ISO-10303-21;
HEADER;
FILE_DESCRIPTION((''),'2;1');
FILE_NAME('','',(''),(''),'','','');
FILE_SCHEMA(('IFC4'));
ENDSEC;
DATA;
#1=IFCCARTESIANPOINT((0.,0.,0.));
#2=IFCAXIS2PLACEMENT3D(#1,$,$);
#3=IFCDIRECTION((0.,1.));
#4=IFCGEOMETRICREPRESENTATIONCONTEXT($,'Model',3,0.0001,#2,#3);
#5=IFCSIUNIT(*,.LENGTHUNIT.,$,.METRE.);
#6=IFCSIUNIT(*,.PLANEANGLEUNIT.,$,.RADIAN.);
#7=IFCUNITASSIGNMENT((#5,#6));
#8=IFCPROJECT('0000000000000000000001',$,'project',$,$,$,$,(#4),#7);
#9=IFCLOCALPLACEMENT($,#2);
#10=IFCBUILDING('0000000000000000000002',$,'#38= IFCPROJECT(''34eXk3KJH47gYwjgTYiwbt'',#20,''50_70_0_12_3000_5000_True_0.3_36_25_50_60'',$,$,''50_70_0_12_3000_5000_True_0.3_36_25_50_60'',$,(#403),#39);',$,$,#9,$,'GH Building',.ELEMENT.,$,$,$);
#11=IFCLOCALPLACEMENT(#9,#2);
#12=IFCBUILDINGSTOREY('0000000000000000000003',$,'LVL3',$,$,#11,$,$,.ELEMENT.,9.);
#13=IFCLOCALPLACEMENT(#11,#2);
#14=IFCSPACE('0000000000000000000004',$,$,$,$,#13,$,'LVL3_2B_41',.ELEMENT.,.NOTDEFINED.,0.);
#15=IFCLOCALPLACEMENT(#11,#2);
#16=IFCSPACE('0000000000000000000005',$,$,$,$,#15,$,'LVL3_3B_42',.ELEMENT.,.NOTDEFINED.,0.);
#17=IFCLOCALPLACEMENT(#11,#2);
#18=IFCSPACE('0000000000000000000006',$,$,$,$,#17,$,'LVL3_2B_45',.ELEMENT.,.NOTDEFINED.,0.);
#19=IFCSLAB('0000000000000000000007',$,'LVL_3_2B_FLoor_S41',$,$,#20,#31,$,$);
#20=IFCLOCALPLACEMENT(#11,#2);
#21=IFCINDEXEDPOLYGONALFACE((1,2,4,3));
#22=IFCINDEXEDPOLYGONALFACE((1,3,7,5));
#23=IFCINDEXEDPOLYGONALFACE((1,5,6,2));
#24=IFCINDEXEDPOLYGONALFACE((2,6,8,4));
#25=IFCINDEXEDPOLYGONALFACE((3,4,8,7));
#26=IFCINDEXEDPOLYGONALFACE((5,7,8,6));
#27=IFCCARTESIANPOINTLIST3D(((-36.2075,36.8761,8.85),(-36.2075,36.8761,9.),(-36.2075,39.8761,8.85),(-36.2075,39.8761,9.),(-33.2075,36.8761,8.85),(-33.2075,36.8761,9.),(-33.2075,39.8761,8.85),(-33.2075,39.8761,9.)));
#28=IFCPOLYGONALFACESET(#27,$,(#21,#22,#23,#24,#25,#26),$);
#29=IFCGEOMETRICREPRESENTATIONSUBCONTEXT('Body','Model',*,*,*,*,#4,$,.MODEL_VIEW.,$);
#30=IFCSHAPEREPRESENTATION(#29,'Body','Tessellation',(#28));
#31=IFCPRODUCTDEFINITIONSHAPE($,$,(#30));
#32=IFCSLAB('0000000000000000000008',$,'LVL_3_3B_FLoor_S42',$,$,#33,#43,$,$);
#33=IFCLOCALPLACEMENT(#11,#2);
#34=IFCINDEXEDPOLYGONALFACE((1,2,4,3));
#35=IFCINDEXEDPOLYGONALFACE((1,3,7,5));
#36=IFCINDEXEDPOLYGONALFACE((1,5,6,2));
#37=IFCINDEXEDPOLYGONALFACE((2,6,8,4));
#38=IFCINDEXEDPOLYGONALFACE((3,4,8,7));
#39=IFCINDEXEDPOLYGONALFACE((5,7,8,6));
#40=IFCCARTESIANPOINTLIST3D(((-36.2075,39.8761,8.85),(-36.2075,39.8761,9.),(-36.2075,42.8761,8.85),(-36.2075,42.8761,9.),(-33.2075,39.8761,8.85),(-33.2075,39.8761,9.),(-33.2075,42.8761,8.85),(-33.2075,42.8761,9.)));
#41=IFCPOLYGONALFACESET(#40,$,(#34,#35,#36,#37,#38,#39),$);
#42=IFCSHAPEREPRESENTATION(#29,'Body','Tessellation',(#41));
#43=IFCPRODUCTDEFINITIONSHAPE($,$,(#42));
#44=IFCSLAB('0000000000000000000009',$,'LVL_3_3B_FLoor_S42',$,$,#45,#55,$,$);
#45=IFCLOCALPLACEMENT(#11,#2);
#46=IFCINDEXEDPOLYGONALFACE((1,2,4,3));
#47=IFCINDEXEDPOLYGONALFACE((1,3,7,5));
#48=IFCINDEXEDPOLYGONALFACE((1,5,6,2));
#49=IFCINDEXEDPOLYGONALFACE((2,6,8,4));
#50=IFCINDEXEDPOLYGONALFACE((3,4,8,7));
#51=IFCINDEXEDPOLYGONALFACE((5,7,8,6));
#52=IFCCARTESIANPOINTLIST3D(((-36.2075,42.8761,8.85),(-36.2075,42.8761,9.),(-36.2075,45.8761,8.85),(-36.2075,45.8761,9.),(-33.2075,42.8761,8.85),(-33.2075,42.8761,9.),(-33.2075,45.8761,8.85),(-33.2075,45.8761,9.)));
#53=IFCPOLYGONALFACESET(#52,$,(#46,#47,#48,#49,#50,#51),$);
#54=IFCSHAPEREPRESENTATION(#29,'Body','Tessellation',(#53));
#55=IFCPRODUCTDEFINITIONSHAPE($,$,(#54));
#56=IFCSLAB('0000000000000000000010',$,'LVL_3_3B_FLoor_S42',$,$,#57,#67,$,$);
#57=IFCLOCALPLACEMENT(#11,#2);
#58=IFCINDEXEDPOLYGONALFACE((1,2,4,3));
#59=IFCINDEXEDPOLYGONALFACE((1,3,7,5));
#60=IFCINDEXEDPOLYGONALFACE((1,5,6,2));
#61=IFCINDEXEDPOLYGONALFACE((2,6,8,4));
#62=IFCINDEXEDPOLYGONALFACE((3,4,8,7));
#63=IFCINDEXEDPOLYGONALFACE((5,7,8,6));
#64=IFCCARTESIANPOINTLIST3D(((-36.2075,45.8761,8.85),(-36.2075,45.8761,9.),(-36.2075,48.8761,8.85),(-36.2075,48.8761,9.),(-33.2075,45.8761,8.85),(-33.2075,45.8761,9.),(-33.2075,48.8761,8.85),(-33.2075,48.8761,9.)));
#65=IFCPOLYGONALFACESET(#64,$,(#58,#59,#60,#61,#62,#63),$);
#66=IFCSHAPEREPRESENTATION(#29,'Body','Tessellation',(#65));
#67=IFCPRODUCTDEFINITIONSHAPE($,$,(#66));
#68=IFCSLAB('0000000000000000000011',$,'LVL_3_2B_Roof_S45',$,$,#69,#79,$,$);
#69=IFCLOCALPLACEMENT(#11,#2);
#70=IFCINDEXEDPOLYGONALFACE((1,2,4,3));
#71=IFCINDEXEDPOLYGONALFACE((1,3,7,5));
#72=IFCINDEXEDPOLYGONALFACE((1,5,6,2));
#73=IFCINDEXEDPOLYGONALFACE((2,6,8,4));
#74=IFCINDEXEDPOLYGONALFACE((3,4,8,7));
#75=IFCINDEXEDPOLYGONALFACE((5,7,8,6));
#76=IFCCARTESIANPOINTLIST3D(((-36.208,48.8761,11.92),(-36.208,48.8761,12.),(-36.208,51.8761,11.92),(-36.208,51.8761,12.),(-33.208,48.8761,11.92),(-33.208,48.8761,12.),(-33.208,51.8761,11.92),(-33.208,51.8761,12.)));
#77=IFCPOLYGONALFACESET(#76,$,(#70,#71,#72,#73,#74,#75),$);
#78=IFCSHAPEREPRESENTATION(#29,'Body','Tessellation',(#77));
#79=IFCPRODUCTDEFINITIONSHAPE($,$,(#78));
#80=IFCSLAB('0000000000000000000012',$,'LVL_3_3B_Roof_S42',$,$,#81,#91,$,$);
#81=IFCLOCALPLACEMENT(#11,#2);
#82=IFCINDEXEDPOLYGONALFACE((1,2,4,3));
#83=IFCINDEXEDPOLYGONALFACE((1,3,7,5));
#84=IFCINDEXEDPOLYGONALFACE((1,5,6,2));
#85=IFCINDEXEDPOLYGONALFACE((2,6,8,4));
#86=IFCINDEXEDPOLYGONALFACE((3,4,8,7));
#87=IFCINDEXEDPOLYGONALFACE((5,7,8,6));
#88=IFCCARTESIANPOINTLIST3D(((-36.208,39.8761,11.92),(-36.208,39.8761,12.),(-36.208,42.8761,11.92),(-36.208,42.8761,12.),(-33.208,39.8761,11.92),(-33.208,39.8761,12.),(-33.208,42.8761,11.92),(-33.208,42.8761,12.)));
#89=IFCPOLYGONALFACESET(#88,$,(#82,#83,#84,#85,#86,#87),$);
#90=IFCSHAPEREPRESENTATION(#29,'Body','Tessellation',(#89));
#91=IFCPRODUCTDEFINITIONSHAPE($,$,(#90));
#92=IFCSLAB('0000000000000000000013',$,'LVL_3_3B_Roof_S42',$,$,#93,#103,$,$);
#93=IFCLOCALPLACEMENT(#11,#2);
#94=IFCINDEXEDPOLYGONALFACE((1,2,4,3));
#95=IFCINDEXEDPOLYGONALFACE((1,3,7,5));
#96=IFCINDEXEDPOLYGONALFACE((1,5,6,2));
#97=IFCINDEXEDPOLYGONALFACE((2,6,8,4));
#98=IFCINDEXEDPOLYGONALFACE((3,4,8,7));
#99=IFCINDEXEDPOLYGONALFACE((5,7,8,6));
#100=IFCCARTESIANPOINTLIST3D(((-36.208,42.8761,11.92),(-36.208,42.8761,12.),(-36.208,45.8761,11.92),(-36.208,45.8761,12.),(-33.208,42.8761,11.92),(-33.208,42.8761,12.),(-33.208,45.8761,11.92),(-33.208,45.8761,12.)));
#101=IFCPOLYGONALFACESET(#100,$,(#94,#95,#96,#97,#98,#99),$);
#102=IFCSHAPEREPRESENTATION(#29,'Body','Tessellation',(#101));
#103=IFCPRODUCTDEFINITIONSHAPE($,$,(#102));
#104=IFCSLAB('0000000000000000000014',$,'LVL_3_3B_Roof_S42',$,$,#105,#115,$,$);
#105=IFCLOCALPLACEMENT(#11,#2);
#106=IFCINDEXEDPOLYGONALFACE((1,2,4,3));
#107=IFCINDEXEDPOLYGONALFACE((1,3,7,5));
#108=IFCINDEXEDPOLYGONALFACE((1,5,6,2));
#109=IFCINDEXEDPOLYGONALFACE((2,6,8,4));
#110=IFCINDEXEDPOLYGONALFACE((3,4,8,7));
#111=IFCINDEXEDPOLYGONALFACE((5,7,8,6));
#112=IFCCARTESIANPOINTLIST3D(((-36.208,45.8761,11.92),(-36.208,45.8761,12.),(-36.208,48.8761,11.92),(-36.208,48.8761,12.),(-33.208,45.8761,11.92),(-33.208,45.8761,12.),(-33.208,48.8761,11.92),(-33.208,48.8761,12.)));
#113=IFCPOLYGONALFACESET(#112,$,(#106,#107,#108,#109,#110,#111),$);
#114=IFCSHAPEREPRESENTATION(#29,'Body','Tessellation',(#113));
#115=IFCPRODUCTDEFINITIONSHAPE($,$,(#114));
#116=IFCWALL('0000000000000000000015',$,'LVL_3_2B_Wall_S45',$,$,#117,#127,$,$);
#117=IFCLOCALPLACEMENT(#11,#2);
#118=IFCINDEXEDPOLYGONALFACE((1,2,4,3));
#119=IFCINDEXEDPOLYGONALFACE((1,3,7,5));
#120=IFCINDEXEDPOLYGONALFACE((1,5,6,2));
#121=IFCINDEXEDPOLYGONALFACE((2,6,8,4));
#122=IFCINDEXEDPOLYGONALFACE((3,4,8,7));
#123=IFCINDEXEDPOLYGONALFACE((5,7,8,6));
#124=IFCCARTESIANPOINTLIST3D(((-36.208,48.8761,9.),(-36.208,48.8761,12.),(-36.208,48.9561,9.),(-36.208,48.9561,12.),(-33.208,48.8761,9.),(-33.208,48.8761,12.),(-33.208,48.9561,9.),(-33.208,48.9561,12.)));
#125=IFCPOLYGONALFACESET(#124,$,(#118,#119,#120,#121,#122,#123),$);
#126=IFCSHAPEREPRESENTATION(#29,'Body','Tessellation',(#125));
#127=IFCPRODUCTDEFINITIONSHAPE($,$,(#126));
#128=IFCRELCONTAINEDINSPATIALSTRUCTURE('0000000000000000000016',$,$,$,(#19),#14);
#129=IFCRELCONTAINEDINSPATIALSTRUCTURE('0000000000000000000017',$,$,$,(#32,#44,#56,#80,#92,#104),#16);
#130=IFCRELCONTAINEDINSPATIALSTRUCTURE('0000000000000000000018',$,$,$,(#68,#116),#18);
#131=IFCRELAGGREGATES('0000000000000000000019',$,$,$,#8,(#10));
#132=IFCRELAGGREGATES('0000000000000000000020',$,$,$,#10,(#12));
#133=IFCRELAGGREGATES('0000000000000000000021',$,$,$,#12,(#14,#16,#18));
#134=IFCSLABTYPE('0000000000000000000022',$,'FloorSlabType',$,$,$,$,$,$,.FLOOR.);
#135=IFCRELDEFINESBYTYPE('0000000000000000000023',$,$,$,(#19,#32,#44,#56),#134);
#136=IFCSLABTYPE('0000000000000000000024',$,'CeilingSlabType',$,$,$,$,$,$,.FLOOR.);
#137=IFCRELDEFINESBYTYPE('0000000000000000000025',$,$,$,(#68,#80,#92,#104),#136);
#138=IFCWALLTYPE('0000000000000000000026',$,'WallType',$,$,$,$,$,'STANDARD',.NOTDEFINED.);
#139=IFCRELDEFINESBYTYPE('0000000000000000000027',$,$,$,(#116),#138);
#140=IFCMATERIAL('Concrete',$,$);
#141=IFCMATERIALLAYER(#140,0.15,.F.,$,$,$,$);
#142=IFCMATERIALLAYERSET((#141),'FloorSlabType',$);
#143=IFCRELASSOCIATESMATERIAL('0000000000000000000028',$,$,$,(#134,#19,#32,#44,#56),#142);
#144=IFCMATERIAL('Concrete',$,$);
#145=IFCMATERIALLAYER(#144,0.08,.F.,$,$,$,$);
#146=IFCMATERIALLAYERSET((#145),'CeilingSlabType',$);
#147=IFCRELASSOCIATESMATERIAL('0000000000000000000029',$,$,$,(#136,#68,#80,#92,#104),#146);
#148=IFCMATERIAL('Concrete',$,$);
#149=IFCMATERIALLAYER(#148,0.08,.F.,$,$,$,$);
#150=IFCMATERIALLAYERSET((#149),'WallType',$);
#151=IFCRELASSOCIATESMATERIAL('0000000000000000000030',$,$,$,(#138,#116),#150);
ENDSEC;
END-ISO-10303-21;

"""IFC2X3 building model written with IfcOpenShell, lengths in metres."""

from ifc_helpers import new_model, si_unit, direction, frame, frame_2d, origin, place, context, subcontext, project, spatial, rectangle, extrude, material, layer, layer_set, layer_usage, type_object, element, save


model = new_model("IFC2X3")

# Units and contexts
model_context = context("Model", 3, precision=0.0001, world=origin(), true_north=direction((0.0, 1.0)))
body_context = subcontext(model_context, "Body", "Model", "MODEL_VIEW")
ifc_project = project(units=[si_unit("LENGTHUNIT", "METRE"), si_unit("PLANEANGLEUNIT", "RADIAN")], contexts=[model_context])

# Building, storey, space
building_placement = place(None, origin())
building = spatial("IfcBuilding", under=ifc_project, at=building_placement, Name="#38= IFCPROJECT('34eXk3KJH47gYwjgTYiwbt',#20,'50_70_0_12_3000_5000_True_0.3_36_25_50_60',$,$,'50_70_0_12_3000_5000_True_0.3_36_25_50_60',$,(#403),#39);", LongName="GH Building", CompositionType="ELEMENT")
storey_placement = place(building_placement, origin())
storey = spatial("IfcBuildingStorey", under=building, at=storey_placement, Name="LVL3", CompositionType="ELEMENT", Elevation=9.0)
space_1_placement = place(storey_placement, origin())
space_1 = spatial("IfcSpace", under=storey, at=space_1_placement, LongName="LVL3_2B_41", CompositionType="ELEMENT", InteriorOrExteriorSpace="NOTDEFINED", ElevationWithFlooring=0.0)

# Slab
ifc_material_1 = material(Name="Concrete")
ifc_layer_1 = layer(ifc_material_1, 0.15, ventilated=False)
ifc_layer_set_1 = layer_set([ifc_layer_1], Name="FloorSlabType")
ifc_layer_usage_1 = layer_usage(ifc_layer_set_1, "AXIS3", "NEGATIVE", -0.15)
slab_type_1 = type_object("IfcSlabType", Name="FloorSlabType", PredefinedType="FLOOR", material=ifc_layer_set_1)
slab_1_placement = place(space_1_placement, frame((-33.2075, 36.8761, 8.85), z_axis=(0.0, 0.0, 1.0), x_axis=(0.0, 1.0, 0.0)))
element("IfcSlab", 1, at=slab_1_placement, inside=space_1, type_object=slab_type_1, material=ifc_layer_usage_1, Name="LVL_3_2B_FLoor_S41", context=body_context, shape_type="SweptSolid", body=[
    extrude(rectangle(XDim=3.0, YDim=3.0, at=frame_2d((1.5, 1.5))), origin(), (0.0, 0.0, 1.0), 0.15),
])

# Shared definitions
space_2_placement = place(storey_placement, origin())
space_2 = spatial("IfcSpace", under=storey, at=space_2_placement, LongName="LVL3_3B_42", CompositionType="ELEMENT", InteriorOrExteriorSpace="NOTDEFINED", ElevationWithFlooring=0.0)

# Slabs
ifc_layer_usage_2 = layer_usage(ifc_layer_set_1, "AXIS3", "NEGATIVE", -0.15)
slab_2_placement = place(space_2_placement, frame((-33.2075, 39.8761, 8.85), z_axis=(0.0, 0.0, 1.0), x_axis=(0.0, 1.0, 0.0)))
element("IfcSlab", 2, at=slab_2_placement, inside=space_2, type_object=slab_type_1, material=ifc_layer_usage_2, Name="LVL_3_3B_FLoor_S42", context=body_context, shape_type="SweptSolid", body=[
    extrude(rectangle(XDim=3.0, YDim=3.0, at=frame_2d((1.5, 1.5))), origin(), (0.0, 0.0, 1.0), 0.15),
])
ifc_layer_usage_3 = layer_usage(ifc_layer_set_1, "AXIS3", "NEGATIVE", -0.15)
slab_3_placement = place(space_2_placement, frame((-33.2075, 42.8761, 8.85), z_axis=(0.0, 0.0, 1.0), x_axis=(0.0, 1.0, 0.0)))
element("IfcSlab", 3, at=slab_3_placement, inside=space_2, type_object=slab_type_1, material=ifc_layer_usage_3, Name="LVL_3_3B_FLoor_S42", context=body_context, shape_type="SweptSolid", body=[
    extrude(rectangle(XDim=3.0, YDim=3.0, at=frame_2d((1.5, 1.5))), origin(), (0.0, 0.0, 1.0), 0.15),
])
ifc_layer_usage_4 = layer_usage(ifc_layer_set_1, "AXIS3", "NEGATIVE", -0.15)
slab_4_placement = place(space_2_placement, frame((-33.2075, 45.8761, 8.85), z_axis=(0.0, 0.0, 1.0), x_axis=(0.0, 1.0, 0.0)))
element("IfcSlab", 4, at=slab_4_placement, inside=space_2, type_object=slab_type_1, material=ifc_layer_usage_4, Name="LVL_3_3B_FLoor_S42", context=body_context, shape_type="SweptSolid", body=[
    extrude(rectangle(XDim=3.0, YDim=3.0, at=frame_2d((1.5, 1.5))), origin(), (0.0, 0.0, 1.0), 0.15),
])

# Shared definitions
space_3_placement = place(storey_placement, origin())
space_3 = spatial("IfcSpace", under=storey, at=space_3_placement, LongName="LVL3_2B_45", CompositionType="ELEMENT", InteriorOrExteriorSpace="NOTDEFINED", ElevationWithFlooring=0.0)

# Slabs
ifc_material_2 = material(Name="Concrete")
ifc_layer_2 = layer(ifc_material_2, 0.08, ventilated=False)
ifc_layer_set_2 = layer_set([ifc_layer_2], Name="CeilingSlabType")
ifc_layer_usage_5 = layer_usage(ifc_layer_set_2, "AXIS3", "NEGATIVE", -0.08)
slab_type_2 = type_object("IfcSlabType", Name="CeilingSlabType", PredefinedType="FLOOR", material=ifc_layer_set_2)
slab_5_placement = place(space_3_placement, frame((-33.208, 48.8761, 11.92), z_axis=(0.0, 0.0, 1.0), x_axis=(0.0, 1.0, 0.0)))
element("IfcSlab", 5, at=slab_5_placement, inside=space_3, type_object=slab_type_2, material=ifc_layer_usage_5, Name="LVL_3_2B_Roof_S45", context=body_context, shape_type="SweptSolid", body=[
    extrude(rectangle(XDim=3.0, YDim=3.0, at=frame_2d((1.5, 1.5))), origin(), (0.0, 0.0, 1.0), 0.08),
])
ifc_layer_usage_6 = layer_usage(ifc_layer_set_2, "AXIS3", "NEGATIVE", -0.08)
slab_6_placement = place(space_2_placement, frame((-33.208, 39.8761, 11.92), z_axis=(0.0, 0.0, 1.0), x_axis=(0.0, 1.0, 0.0)))
element("IfcSlab", 6, at=slab_6_placement, inside=space_2, type_object=slab_type_2, material=ifc_layer_usage_6, Name="LVL_3_3B_Roof_S42", context=body_context, shape_type="SweptSolid", body=[
    extrude(rectangle(XDim=3.0, YDim=3.0, at=frame_2d((1.5, 1.5))), origin(), (0.0, 0.0, 1.0), 0.08),
])
ifc_layer_usage_7 = layer_usage(ifc_layer_set_2, "AXIS3", "NEGATIVE", -0.08)
slab_7_placement = place(space_2_placement, frame((-33.208, 42.8761, 11.92), z_axis=(0.0, 0.0, 1.0), x_axis=(0.0, 1.0, 0.0)))
element("IfcSlab", 7, at=slab_7_placement, inside=space_2, type_object=slab_type_2, material=ifc_layer_usage_7, Name="LVL_3_3B_Roof_S42", context=body_context, shape_type="SweptSolid", body=[
    extrude(rectangle(XDim=3.0, YDim=3.0, at=frame_2d((1.5, 1.5))), origin(), (0.0, 0.0, 1.0), 0.08),
])
ifc_layer_usage_8 = layer_usage(ifc_layer_set_2, "AXIS3", "NEGATIVE", -0.08)
slab_8_placement = place(space_2_placement, frame((-33.208, 48.8761, 11.92), z_axis=(0.0, 0.0, 1.0), x_axis=(0.0, -1.0, 0.0)))
element("IfcSlab", 8, at=slab_8_placement, inside=space_2, type_object=slab_type_2, material=ifc_layer_usage_8, Name="LVL_3_3B_Roof_S42", context=body_context, shape_type="SweptSolid", body=[
    extrude(rectangle(XDim=3.0, YDim=3.0, at=frame_2d((1.5, -1.5))), origin(), (0.0, 0.0, 1.0), 0.08),
])

# Shared definitions
ifc_material_3 = material(Name="Concrete")
ifc_layer_3 = layer(ifc_material_3, 0.08, ventilated=False)
ifc_layer_set_3 = layer_set([ifc_layer_3], Name="WallType")
wall_type = type_object("IfcWallType", Name="WallType", ElementType="STANDARD", PredefinedType="NOTDEFINED", material=ifc_layer_set_3)

# Wall
ifc_layer_usage_9 = layer_usage(ifc_layer_set_3, "AXIS2", "NEGATIVE", 0.0)
wall_1_placement = place(space_3_placement, frame((-33.208, 48.8761, 9.0), z_axis=(0.0, 0.0, 1.0), x_axis=(-1.0, 0.0, 0.0)))
element("IfcWall", 9, at=wall_1_placement, inside=space_3, type_object=wall_type, material=ifc_layer_usage_9, Name="LVL_3_2B_Wall_S45", context=body_context, shape_type="SweptSolid", body=[
    extrude(rectangle(XDim=3.0, YDim=0.08, at=frame_2d((1.5, -0.04))), origin(), (0.0, 0.0, 1.0), 3.0),
])

save(model, "model.ifc")
